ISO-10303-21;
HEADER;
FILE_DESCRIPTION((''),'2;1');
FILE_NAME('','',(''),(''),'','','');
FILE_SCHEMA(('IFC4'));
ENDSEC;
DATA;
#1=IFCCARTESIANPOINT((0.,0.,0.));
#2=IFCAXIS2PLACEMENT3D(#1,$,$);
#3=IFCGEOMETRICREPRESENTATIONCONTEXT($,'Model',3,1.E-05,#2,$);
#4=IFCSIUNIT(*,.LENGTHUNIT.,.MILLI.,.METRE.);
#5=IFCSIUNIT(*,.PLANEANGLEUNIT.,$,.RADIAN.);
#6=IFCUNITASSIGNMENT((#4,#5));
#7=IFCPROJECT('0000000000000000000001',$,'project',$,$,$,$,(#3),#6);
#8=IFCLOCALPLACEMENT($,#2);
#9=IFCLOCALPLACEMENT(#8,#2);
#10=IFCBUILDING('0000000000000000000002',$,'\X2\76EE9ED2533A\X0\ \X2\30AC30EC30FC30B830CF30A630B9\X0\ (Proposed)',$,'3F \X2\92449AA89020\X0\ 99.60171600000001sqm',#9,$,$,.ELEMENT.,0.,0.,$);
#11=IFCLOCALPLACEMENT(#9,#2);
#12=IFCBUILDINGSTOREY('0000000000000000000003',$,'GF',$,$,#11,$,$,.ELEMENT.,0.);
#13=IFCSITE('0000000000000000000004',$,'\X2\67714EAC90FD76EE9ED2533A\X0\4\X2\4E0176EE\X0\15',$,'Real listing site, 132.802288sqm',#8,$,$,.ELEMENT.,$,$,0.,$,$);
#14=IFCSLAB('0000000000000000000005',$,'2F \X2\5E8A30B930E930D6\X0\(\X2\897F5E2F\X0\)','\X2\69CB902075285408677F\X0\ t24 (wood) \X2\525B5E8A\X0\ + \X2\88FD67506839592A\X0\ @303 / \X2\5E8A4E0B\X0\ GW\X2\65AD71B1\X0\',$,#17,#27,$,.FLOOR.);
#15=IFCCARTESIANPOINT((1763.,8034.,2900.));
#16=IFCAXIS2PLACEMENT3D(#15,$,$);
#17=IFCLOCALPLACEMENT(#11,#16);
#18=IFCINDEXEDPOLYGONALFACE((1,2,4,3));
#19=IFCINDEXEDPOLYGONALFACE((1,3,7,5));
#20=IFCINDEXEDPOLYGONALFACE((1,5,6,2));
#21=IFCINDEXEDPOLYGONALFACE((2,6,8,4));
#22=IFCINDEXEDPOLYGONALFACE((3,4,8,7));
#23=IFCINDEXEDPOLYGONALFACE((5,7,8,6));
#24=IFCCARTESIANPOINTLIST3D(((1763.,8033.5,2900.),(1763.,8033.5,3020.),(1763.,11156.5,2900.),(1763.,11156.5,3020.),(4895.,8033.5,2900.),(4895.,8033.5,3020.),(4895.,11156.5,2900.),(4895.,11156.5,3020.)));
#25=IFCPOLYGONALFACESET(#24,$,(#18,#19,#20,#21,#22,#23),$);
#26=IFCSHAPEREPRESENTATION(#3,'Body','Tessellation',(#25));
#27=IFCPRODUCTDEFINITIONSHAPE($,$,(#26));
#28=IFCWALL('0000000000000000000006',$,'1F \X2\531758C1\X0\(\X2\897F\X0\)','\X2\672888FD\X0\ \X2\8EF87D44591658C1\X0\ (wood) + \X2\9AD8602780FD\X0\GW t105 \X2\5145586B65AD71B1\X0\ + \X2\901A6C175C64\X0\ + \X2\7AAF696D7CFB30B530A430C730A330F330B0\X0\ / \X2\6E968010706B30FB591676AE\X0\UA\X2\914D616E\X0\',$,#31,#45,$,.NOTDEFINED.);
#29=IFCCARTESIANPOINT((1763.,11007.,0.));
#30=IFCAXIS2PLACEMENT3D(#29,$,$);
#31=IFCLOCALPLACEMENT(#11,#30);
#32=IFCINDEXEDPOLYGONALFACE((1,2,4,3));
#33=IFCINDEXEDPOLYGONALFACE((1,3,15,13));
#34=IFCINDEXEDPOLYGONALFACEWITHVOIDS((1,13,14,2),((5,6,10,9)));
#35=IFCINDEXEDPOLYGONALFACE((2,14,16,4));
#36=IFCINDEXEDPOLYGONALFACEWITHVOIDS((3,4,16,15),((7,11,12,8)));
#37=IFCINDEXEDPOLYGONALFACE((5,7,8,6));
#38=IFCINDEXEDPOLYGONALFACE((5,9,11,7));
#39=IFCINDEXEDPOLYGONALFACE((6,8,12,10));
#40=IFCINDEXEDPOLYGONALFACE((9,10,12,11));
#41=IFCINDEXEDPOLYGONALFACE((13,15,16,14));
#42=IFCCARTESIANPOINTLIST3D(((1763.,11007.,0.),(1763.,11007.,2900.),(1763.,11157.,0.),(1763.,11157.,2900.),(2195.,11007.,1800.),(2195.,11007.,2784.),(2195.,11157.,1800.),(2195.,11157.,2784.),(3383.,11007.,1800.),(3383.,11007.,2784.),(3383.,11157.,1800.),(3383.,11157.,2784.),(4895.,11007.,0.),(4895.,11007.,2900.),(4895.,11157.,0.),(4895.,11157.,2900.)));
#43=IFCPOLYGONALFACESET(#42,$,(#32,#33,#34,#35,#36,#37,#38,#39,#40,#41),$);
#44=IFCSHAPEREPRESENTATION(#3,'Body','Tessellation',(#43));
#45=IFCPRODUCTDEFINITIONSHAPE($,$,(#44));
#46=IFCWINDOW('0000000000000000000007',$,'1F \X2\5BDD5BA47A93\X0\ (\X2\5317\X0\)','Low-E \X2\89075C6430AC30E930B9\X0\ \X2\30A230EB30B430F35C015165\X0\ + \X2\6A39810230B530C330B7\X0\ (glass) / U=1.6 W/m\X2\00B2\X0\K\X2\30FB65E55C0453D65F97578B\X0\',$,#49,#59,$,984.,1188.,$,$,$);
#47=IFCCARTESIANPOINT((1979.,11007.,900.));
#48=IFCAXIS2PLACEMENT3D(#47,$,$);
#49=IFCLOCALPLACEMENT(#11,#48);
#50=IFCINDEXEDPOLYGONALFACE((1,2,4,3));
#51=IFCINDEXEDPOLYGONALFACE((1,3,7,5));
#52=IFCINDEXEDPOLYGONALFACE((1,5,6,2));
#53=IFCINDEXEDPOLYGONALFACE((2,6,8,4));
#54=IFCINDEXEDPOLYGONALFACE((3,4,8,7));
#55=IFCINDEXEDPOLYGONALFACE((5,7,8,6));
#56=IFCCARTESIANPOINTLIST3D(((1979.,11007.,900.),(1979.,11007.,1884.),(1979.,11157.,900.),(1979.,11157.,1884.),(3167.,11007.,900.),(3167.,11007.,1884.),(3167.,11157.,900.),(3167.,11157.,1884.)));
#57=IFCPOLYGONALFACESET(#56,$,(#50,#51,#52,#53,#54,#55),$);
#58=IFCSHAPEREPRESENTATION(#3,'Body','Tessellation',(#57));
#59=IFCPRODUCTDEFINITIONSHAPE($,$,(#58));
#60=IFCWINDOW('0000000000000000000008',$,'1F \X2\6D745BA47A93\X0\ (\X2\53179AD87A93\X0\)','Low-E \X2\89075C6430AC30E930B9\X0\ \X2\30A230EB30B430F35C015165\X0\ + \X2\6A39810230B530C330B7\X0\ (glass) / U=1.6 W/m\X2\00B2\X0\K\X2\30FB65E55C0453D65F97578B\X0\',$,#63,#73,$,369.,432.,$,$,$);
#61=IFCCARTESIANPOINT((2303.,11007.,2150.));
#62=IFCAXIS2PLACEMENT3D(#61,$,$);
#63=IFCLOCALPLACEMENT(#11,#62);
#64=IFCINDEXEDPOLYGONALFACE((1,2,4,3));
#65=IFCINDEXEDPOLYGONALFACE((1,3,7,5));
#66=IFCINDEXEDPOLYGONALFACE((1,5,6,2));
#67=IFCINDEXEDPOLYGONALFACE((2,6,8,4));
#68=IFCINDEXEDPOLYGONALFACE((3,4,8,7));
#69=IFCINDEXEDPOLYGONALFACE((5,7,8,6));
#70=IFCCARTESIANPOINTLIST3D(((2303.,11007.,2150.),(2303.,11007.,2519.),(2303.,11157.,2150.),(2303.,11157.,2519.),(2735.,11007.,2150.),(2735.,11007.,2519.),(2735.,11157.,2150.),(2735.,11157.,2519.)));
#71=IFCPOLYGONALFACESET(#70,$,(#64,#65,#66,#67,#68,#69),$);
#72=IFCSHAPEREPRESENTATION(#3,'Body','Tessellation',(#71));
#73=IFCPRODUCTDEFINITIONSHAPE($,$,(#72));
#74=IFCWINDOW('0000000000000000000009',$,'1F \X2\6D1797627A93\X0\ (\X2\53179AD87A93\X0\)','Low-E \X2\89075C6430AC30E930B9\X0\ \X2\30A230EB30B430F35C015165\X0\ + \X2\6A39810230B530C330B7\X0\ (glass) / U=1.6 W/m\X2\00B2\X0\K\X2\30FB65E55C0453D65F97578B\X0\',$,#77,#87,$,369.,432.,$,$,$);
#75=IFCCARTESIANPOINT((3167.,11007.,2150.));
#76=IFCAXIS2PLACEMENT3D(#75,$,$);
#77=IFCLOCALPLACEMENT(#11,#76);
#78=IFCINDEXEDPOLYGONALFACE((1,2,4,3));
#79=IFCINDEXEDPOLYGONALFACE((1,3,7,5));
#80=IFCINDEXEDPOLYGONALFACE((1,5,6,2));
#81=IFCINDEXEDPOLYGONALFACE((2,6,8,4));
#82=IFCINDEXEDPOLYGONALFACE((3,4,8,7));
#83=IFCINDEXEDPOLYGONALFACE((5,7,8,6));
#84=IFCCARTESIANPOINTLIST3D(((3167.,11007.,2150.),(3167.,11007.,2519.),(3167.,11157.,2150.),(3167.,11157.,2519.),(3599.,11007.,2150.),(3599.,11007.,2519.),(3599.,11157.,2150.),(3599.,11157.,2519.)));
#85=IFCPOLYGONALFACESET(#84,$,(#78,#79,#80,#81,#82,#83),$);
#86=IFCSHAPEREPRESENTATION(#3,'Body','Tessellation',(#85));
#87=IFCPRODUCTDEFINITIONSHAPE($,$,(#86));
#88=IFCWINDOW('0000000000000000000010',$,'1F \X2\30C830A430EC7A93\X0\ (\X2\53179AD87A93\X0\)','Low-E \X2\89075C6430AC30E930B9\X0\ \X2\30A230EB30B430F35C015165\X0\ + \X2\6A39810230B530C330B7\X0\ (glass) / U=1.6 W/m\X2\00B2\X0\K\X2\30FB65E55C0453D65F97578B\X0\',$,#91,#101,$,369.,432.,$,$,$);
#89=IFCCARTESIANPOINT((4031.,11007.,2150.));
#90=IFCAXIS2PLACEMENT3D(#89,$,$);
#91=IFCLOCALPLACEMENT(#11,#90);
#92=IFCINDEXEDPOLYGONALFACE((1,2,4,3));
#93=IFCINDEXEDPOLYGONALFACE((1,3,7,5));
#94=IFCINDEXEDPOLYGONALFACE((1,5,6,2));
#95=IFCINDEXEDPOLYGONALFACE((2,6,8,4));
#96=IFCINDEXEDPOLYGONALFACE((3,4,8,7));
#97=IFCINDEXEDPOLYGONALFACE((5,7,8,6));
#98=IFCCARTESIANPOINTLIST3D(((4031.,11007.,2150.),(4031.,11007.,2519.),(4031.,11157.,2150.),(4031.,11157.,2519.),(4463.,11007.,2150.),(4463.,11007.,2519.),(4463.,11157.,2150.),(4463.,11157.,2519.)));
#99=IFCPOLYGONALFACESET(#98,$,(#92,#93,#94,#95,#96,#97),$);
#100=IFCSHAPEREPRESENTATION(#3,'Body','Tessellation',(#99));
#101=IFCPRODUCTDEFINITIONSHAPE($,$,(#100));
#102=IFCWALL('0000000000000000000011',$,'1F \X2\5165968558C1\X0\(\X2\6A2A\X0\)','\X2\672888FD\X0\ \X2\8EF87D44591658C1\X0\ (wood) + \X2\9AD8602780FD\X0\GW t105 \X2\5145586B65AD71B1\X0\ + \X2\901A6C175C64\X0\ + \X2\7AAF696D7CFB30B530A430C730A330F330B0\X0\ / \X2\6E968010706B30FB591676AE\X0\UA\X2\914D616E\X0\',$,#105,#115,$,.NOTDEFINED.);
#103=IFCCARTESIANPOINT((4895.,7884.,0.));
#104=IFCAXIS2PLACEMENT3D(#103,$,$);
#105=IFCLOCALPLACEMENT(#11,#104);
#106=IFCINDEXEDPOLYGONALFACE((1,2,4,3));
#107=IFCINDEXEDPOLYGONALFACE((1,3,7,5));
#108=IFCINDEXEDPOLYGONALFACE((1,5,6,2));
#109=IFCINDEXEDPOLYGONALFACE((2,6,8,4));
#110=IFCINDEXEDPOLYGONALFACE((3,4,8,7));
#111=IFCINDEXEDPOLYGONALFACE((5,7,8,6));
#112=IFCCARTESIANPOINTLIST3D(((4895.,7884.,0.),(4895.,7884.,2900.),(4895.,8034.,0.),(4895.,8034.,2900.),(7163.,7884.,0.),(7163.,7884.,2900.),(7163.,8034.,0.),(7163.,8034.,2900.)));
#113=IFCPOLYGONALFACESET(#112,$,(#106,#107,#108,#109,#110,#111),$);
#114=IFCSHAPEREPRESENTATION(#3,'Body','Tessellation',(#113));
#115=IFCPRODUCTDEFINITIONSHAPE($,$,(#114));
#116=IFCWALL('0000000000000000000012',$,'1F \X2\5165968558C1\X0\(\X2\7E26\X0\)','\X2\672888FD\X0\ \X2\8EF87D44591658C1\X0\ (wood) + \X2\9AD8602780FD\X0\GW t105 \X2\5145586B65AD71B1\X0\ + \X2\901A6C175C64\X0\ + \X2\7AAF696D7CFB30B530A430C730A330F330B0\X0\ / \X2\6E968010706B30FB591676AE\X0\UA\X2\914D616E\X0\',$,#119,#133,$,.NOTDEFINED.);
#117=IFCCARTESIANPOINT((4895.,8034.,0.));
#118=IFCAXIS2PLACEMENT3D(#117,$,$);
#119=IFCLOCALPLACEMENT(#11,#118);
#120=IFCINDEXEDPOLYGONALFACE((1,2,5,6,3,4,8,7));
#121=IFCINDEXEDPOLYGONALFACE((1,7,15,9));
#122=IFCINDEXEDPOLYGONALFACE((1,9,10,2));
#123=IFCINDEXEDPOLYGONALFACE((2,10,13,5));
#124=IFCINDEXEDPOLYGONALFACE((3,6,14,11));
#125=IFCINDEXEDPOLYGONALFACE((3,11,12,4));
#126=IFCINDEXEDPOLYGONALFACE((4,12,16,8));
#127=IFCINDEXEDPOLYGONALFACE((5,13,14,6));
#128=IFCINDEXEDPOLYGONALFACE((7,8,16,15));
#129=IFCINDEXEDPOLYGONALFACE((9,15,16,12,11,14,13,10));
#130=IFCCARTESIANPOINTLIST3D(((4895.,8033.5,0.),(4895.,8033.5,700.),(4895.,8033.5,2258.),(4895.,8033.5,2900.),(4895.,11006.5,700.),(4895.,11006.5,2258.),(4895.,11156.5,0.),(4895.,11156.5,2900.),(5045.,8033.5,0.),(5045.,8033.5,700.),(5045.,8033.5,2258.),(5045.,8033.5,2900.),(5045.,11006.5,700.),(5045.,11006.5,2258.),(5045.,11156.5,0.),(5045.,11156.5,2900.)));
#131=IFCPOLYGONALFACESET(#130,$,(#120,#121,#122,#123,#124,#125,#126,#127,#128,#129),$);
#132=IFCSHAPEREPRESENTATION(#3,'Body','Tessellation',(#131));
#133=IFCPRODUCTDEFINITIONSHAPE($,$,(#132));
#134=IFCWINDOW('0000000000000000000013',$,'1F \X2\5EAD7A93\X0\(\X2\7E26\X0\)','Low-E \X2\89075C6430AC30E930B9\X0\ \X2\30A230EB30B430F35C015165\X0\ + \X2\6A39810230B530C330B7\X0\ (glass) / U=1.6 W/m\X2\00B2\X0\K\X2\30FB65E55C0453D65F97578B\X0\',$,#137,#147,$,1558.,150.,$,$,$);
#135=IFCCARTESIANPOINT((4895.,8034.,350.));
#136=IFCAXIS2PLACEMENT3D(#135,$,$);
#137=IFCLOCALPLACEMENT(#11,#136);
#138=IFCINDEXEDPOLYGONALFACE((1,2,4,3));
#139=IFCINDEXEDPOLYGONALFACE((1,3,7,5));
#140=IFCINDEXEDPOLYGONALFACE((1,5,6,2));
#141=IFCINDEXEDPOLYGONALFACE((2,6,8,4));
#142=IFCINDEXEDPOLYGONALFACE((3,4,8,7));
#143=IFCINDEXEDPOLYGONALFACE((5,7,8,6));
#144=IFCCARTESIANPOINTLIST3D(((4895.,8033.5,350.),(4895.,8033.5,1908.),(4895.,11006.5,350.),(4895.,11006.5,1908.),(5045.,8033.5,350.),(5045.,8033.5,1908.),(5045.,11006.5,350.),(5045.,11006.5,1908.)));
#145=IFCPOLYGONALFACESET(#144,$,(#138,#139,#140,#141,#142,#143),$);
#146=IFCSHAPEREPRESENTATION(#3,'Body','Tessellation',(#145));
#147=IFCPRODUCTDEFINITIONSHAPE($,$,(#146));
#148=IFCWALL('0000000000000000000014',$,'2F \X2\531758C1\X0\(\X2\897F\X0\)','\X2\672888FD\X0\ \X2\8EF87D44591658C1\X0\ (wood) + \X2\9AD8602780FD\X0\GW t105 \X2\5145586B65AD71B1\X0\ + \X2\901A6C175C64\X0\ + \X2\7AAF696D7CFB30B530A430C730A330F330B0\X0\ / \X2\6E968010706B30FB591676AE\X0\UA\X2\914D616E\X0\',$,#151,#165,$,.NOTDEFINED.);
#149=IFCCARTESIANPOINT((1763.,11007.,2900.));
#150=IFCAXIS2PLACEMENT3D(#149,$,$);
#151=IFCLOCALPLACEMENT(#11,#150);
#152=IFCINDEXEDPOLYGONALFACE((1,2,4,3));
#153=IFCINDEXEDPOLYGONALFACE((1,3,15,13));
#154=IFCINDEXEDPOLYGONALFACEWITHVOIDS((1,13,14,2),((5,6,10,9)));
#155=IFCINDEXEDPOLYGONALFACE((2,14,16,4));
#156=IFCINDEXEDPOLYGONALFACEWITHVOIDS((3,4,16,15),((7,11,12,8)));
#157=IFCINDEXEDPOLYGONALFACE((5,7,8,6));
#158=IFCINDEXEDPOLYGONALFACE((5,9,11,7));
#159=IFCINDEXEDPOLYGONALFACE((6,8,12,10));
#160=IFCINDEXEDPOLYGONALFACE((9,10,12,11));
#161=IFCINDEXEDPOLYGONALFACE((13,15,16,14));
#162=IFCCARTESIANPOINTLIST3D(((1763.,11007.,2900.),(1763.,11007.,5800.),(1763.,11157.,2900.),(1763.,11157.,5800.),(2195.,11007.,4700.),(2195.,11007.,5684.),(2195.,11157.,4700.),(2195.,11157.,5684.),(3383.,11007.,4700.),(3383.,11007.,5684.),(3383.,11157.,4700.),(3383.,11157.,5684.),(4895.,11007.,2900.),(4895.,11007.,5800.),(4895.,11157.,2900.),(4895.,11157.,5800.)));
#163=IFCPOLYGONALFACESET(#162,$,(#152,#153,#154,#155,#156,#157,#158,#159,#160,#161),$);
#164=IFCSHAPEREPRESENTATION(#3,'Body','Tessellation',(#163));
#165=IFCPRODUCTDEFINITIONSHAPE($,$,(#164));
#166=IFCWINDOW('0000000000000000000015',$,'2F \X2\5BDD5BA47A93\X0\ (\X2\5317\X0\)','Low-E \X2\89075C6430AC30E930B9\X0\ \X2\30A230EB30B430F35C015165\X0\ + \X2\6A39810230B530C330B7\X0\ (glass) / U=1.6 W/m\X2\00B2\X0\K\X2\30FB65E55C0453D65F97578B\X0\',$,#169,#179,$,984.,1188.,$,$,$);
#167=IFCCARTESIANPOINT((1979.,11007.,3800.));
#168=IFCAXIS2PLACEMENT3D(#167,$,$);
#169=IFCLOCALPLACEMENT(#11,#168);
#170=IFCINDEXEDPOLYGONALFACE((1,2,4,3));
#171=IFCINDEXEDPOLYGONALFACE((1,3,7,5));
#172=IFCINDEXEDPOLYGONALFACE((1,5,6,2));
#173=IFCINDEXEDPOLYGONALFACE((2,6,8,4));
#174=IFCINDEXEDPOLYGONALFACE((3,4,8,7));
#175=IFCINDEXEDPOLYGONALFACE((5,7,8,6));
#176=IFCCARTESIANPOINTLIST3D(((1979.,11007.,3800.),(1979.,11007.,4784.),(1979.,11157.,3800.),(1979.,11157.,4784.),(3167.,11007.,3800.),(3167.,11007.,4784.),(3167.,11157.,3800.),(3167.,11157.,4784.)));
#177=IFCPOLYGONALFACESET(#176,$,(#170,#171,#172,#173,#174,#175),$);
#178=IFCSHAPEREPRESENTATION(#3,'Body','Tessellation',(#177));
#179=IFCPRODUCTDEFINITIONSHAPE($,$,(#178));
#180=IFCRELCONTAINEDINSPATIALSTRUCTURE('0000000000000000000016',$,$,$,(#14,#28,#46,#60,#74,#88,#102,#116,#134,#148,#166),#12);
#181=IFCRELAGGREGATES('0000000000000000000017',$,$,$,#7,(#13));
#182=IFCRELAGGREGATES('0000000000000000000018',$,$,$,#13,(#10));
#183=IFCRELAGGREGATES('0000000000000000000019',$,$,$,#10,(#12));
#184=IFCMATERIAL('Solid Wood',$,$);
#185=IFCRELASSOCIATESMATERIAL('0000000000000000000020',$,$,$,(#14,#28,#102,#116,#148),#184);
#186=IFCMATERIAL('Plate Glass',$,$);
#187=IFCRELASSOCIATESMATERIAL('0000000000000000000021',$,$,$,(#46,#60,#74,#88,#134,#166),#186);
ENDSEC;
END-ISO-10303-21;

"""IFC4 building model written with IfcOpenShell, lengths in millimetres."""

from ifc_helpers import new_model, si_unit, frame, frame_2d, origin, place, context, project, spatial, rectangle, extrude, material, element, fill, save


model = new_model("IFC4")

# Units and contexts
model_context = context("Model", 3, precision=1e-05, world=origin())
ifc_project = project(units=[si_unit("LENGTHUNIT", "METRE", prefix="MILLI"), si_unit("PLANEANGLEUNIT", "RADIAN")], contexts=[model_context])

# Site, building, storey
site_placement = place(None, origin())
site = spatial("IfcSite", under=ifc_project, at=site_placement, Name="東京都目黒区4丁目15", ObjectType="Real listing site, 132.802288sqm", CompositionType="ELEMENT", RefElevation=0.0)
building_placement = place(site_placement, origin())
building = spatial("IfcBuilding", under=site, at=building_placement, Name="目黒区 ガレージハウス (Proposed)", ObjectType="3F 鉄骨造 99.60171600000001sqm", CompositionType="ELEMENT", ElevationOfRefHeight=0.0, ElevationOfTerrain=0.0)
storey_placement = place(building_placement, origin())
storey = spatial("IfcBuildingStorey", under=building, at=storey_placement, Name="GF", CompositionType="ELEMENT", Elevation=0.0)

# Slab
ifc_material_1 = material(Name="Solid Wood")
slab_1_placement = place(storey_placement, frame((1763.0, 8034.0, 2900.0)))
element("IfcSlab", 1, at=slab_1_placement, inside=storey, material=ifc_material_1, Name="2F 床スラブ(西帯)", Description="構造用合板 t24 (wood) 剛床 + 製材根太 @303 / 床下 GW断熱", PredefinedType="FLOOR", context=model_context, shape_type="SweptSolid", body=[
    extrude(rectangle(XDim=3132.0, YDim=3123.0, at=frame_2d((1566.0, 1561.0))), frame((1763.0, 8034.0, 2900.0)), (0.0, 0.0, 1.0), 120.0),
])

# Wall, openings, windows
wall_1_placement = place(storey_placement, frame((1763.0, 11007.0, 0.0)))
wall_1 = element("IfcWall", 2, at=wall_1_placement, inside=storey, material=ifc_material_1, Name="1F 北壁(西)", Description="木製 軸組外壁 (wood) + 高性能GW t105 充填断熱 + 通気層 + 窯業系サイディング / 準耐火・外皮UA配慮", PredefinedType="NOTDEFINED", context=model_context, shape_type="SweptSolid", body=[
    extrude(rectangle(XDim=3132.0, YDim=150.0, at=frame_2d((1566.0, 75.0))), frame((1763.0, 11007.0, 0.0)), (0.0, 0.0, 1.0), 2900.0),
])
opening_1_placement = place(storey_placement, frame((1979.0, 11007.0, 900.0)))
opening_1 = element("IfcOpeningElement", 3, at=opening_1_placement, cuts=wall_1, PredefinedType="NOTDEFINED", context=model_context, shape_type="SweptSolid", body=[
    extrude(rectangle(XDim=1188.0, YDim=150.0, at=frame_2d((594.0, 75.0))), frame((1979.0, 11007.0, 900.0)), (0.0, 0.0, 1.0), 984.0),
])
opening_2_placement = place(storey_placement, frame((2303.0, 11007.0, 2150.0)))
opening_2 = element("IfcOpeningElement", 4, at=opening_2_placement, cuts=wall_1, PredefinedType="NOTDEFINED", context=model_context, shape_type="SweptSolid", body=[
    extrude(rectangle(XDim=432.0, YDim=150.0, at=frame_2d((216.0, 75.0))), frame((2303.0, 11007.0, 2150.0)), (0.0, 0.0, 1.0), 369.0),
])
opening_3_placement = place(storey_placement, frame((3167.0, 11007.0, 2150.0)))
opening_3 = element("IfcOpeningElement", 5, at=opening_3_placement, cuts=wall_1, PredefinedType="NOTDEFINED", context=model_context, shape_type="SweptSolid", body=[
    extrude(rectangle(XDim=432.0, YDim=150.0, at=frame_2d((216.0, 75.0))), frame((3167.0, 11007.0, 2150.0)), (0.0, 0.0, 1.0), 369.0),
])
opening_4_placement = place(storey_placement, frame((4031.0, 11007.0, 2150.0)))
opening_4 = element("IfcOpeningElement", 6, at=opening_4_placement, cuts=wall_1, PredefinedType="NOTDEFINED", context=model_context, shape_type="SweptSolid", body=[
    extrude(rectangle(XDim=432.0, YDim=150.0, at=frame_2d((216.0, 75.0))), frame((4031.0, 11007.0, 2150.0)), (0.0, 0.0, 1.0), 369.0),
])
ifc_material_2 = material(Name="Plate Glass")
window_1_placement = place(storey_placement, frame((1979.0, 11007.0, 900.0)))
window_1 = element("IfcWindow", 7, at=window_1_placement, inside=storey, material=ifc_material_2, Name="1F 寝室窓 (北)", Description="Low-E 複層ガラス アルゴン封入 + 樹脂サッシ (glass) / U=1.6 W/m²K・日射取得型", OverallHeight=984.0, OverallWidth=1188.0, context=model_context, shape_type="SweptSolid", body=[
    extrude(rectangle(XDim=1188.0, YDim=150.0, at=frame_2d((594.0, 75.0))), frame((1979.0, 11007.0, 900.0)), (0.0, 0.0, 1.0), 984.0),
])
fill(opening_1, window_1)
window_2_placement = place(storey_placement, frame((2303.0, 11007.0, 2150.0)))
window_2 = element("IfcWindow", 8, at=window_2_placement, inside=storey, material=ifc_material_2, Name="1F 浴室窓 (北高窓)", Description="Low-E 複層ガラス アルゴン封入 + 樹脂サッシ (glass) / U=1.6 W/m²K・日射取得型", OverallHeight=369.0, OverallWidth=432.0, context=model_context, shape_type="SweptSolid", body=[
    extrude(rectangle(XDim=432.0, YDim=150.0, at=frame_2d((216.0, 75.0))), frame((2303.0, 11007.0, 2150.0)), (0.0, 0.0, 1.0), 369.0),
])
fill(opening_2, window_2)
window_3_placement = place(storey_placement, frame((3167.0, 11007.0, 2150.0)))
window_3 = element("IfcWindow", 9, at=window_3_placement, inside=storey, material=ifc_material_2, Name="1F 洗面窓 (北高窓)", Description="Low-E 複層ガラス アルゴン封入 + 樹脂サッシ (glass) / U=1.6 W/m²K・日射取得型", OverallHeight=369.0, OverallWidth=432.0, context=model_context, shape_type="SweptSolid", body=[
    extrude(rectangle(XDim=432.0, YDim=150.0, at=frame_2d((216.0, 75.0))), frame((3167.0, 11007.0, 2150.0)), (0.0, 0.0, 1.0), 369.0),
])
fill(opening_3, window_3)
window_4_placement = place(storey_placement, frame((4031.0, 11007.0, 2150.0)))
window_4 = element("IfcWindow", 10, at=window_4_placement, inside=storey, material=ifc_material_2, Name="1F トイレ窓 (北高窓)", Description="Low-E 複層ガラス アルゴン封入 + 樹脂サッシ (glass) / U=1.6 W/m²K・日射取得型", OverallHeight=369.0, OverallWidth=432.0, context=model_context, shape_type="SweptSolid", body=[
    extrude(rectangle(XDim=432.0, YDim=150.0, at=frame_2d((216.0, 75.0))), frame((4031.0, 11007.0, 2150.0)), (0.0, 0.0, 1.0), 369.0),
])
fill(opening_4, window_4)

# Wall
wall_2_placement = place(storey_placement, frame((4895.0, 7884.0, 0.0)))
element("IfcWall", 11, at=wall_2_placement, inside=storey, material=ifc_material_1, Name="1F 入隅壁(横)", Description="木製 軸組外壁 (wood) + 高性能GW t105 充填断熱 + 通気層 + 窯業系サイディング / 準耐火・外皮UA配慮", PredefinedType="NOTDEFINED", context=model_context, shape_type="SweptSolid", body=[
    extrude(rectangle(XDim=2268.0, YDim=150.0, at=frame_2d((1134.0, 75.0))), frame((4895.0, 7884.0, 0.0)), (0.0, 0.0, 1.0), 2900.0),
])

# Wall, opening, window
wall_3_placement = place(storey_placement, frame((4895.0, 8034.0, 0.0)))
wall_3 = element("IfcWall", 12, at=wall_3_placement, inside=storey, material=ifc_material_1, Name="1F 入隅壁(縦)", Description="木製 軸組外壁 (wood) + 高性能GW t105 充填断熱 + 通気層 + 窯業系サイディング / 準耐火・外皮UA配慮", PredefinedType="NOTDEFINED", context=model_context, shape_type="SweptSolid", body=[
    extrude(rectangle(XDim=150.0, YDim=3123.0, at=frame_2d((75.0, 1561.0))), frame((4895.0, 8034.0, 0.0)), (0.0, 0.0, 1.0), 2900.0),
])
opening_5_placement = place(storey_placement, frame((4895.0, 8034.0, 350.0)))
opening_5 = element("IfcOpeningElement", 13, at=opening_5_placement, cuts=wall_3, PredefinedType="NOTDEFINED", context=model_context, shape_type="SweptSolid", body=[
    extrude(rectangle(XDim=150.0, YDim=2973.0, at=frame_2d((75.0, 1486.0))), frame((4895.0, 8034.0, 350.0)), (0.0, 0.0, 1.0), 1558.0),
])
window_5_placement = place(storey_placement, frame((4895.0, 8034.0, 350.0)))
window_5 = element("IfcWindow", 14, at=window_5_placement, inside=storey, material=ifc_material_2, Name="1F 庭窓(縦)", Description="Low-E 複層ガラス アルゴン封入 + 樹脂サッシ (glass) / U=1.6 W/m²K・日射取得型", OverallHeight=1558.0, OverallWidth=150.0, context=model_context, shape_type="SweptSolid", body=[
    extrude(rectangle(XDim=150.0, YDim=2973.0, at=frame_2d((75.0, 1486.0))), frame((4895.0, 8034.0, 350.0)), (0.0, 0.0, 1.0), 1558.0),
])
fill(opening_5, window_5)

# Wall, opening, window
wall_4_placement = place(storey_placement, frame((1763.0, 11007.0, 2900.0)))
wall_4 = element("IfcWall", 15, at=wall_4_placement, inside=storey, material=ifc_material_1, Name="2F 北壁(西)", Description="木製 軸組外壁 (wood) + 高性能GW t105 充填断熱 + 通気層 + 窯業系サイディング / 準耐火・外皮UA配慮", PredefinedType="NOTDEFINED", context=model_context, shape_type="SweptSolid", body=[
    extrude(rectangle(XDim=3132.0, YDim=150.0, at=frame_2d((1566.0, 75.0))), frame((1763.0, 11007.0, 2900.0)), (0.0, 0.0, 1.0), 2900.0),
])
opening_6_placement = place(storey_placement, frame((1979.0, 11007.0, 3800.0)))
opening_6 = element("IfcOpeningElement", 16, at=opening_6_placement, cuts=wall_4, PredefinedType="NOTDEFINED", context=model_context, shape_type="SweptSolid", body=[
    extrude(rectangle(XDim=1188.0, YDim=150.0, at=frame_2d((594.0, 75.0))), frame((1979.0, 11007.0, 3800.0)), (0.0, 0.0, 1.0), 984.0),
])
window_6_placement = place(storey_placement, frame((1979.0, 11007.0, 3800.0)))
window_6 = element("IfcWindow", 17, at=window_6_placement, inside=storey, material=ifc_material_2, Name="2F 寝室窓 (北)", Description="Low-E 複層ガラス アルゴン封入 + 樹脂サッシ (glass) / U=1.6 W/m²K・日射取得型", OverallHeight=984.0, OverallWidth=1188.0, context=model_context, shape_type="SweptSolid", body=[
    extrude(rectangle(XDim=1188.0, YDim=150.0, at=frame_2d((594.0, 75.0))), frame((1979.0, 11007.0, 3800.0)), (0.0, 0.0, 1.0), 984.0),
])
fill(opening_6, window_6)

save(model, "model.ifc")
